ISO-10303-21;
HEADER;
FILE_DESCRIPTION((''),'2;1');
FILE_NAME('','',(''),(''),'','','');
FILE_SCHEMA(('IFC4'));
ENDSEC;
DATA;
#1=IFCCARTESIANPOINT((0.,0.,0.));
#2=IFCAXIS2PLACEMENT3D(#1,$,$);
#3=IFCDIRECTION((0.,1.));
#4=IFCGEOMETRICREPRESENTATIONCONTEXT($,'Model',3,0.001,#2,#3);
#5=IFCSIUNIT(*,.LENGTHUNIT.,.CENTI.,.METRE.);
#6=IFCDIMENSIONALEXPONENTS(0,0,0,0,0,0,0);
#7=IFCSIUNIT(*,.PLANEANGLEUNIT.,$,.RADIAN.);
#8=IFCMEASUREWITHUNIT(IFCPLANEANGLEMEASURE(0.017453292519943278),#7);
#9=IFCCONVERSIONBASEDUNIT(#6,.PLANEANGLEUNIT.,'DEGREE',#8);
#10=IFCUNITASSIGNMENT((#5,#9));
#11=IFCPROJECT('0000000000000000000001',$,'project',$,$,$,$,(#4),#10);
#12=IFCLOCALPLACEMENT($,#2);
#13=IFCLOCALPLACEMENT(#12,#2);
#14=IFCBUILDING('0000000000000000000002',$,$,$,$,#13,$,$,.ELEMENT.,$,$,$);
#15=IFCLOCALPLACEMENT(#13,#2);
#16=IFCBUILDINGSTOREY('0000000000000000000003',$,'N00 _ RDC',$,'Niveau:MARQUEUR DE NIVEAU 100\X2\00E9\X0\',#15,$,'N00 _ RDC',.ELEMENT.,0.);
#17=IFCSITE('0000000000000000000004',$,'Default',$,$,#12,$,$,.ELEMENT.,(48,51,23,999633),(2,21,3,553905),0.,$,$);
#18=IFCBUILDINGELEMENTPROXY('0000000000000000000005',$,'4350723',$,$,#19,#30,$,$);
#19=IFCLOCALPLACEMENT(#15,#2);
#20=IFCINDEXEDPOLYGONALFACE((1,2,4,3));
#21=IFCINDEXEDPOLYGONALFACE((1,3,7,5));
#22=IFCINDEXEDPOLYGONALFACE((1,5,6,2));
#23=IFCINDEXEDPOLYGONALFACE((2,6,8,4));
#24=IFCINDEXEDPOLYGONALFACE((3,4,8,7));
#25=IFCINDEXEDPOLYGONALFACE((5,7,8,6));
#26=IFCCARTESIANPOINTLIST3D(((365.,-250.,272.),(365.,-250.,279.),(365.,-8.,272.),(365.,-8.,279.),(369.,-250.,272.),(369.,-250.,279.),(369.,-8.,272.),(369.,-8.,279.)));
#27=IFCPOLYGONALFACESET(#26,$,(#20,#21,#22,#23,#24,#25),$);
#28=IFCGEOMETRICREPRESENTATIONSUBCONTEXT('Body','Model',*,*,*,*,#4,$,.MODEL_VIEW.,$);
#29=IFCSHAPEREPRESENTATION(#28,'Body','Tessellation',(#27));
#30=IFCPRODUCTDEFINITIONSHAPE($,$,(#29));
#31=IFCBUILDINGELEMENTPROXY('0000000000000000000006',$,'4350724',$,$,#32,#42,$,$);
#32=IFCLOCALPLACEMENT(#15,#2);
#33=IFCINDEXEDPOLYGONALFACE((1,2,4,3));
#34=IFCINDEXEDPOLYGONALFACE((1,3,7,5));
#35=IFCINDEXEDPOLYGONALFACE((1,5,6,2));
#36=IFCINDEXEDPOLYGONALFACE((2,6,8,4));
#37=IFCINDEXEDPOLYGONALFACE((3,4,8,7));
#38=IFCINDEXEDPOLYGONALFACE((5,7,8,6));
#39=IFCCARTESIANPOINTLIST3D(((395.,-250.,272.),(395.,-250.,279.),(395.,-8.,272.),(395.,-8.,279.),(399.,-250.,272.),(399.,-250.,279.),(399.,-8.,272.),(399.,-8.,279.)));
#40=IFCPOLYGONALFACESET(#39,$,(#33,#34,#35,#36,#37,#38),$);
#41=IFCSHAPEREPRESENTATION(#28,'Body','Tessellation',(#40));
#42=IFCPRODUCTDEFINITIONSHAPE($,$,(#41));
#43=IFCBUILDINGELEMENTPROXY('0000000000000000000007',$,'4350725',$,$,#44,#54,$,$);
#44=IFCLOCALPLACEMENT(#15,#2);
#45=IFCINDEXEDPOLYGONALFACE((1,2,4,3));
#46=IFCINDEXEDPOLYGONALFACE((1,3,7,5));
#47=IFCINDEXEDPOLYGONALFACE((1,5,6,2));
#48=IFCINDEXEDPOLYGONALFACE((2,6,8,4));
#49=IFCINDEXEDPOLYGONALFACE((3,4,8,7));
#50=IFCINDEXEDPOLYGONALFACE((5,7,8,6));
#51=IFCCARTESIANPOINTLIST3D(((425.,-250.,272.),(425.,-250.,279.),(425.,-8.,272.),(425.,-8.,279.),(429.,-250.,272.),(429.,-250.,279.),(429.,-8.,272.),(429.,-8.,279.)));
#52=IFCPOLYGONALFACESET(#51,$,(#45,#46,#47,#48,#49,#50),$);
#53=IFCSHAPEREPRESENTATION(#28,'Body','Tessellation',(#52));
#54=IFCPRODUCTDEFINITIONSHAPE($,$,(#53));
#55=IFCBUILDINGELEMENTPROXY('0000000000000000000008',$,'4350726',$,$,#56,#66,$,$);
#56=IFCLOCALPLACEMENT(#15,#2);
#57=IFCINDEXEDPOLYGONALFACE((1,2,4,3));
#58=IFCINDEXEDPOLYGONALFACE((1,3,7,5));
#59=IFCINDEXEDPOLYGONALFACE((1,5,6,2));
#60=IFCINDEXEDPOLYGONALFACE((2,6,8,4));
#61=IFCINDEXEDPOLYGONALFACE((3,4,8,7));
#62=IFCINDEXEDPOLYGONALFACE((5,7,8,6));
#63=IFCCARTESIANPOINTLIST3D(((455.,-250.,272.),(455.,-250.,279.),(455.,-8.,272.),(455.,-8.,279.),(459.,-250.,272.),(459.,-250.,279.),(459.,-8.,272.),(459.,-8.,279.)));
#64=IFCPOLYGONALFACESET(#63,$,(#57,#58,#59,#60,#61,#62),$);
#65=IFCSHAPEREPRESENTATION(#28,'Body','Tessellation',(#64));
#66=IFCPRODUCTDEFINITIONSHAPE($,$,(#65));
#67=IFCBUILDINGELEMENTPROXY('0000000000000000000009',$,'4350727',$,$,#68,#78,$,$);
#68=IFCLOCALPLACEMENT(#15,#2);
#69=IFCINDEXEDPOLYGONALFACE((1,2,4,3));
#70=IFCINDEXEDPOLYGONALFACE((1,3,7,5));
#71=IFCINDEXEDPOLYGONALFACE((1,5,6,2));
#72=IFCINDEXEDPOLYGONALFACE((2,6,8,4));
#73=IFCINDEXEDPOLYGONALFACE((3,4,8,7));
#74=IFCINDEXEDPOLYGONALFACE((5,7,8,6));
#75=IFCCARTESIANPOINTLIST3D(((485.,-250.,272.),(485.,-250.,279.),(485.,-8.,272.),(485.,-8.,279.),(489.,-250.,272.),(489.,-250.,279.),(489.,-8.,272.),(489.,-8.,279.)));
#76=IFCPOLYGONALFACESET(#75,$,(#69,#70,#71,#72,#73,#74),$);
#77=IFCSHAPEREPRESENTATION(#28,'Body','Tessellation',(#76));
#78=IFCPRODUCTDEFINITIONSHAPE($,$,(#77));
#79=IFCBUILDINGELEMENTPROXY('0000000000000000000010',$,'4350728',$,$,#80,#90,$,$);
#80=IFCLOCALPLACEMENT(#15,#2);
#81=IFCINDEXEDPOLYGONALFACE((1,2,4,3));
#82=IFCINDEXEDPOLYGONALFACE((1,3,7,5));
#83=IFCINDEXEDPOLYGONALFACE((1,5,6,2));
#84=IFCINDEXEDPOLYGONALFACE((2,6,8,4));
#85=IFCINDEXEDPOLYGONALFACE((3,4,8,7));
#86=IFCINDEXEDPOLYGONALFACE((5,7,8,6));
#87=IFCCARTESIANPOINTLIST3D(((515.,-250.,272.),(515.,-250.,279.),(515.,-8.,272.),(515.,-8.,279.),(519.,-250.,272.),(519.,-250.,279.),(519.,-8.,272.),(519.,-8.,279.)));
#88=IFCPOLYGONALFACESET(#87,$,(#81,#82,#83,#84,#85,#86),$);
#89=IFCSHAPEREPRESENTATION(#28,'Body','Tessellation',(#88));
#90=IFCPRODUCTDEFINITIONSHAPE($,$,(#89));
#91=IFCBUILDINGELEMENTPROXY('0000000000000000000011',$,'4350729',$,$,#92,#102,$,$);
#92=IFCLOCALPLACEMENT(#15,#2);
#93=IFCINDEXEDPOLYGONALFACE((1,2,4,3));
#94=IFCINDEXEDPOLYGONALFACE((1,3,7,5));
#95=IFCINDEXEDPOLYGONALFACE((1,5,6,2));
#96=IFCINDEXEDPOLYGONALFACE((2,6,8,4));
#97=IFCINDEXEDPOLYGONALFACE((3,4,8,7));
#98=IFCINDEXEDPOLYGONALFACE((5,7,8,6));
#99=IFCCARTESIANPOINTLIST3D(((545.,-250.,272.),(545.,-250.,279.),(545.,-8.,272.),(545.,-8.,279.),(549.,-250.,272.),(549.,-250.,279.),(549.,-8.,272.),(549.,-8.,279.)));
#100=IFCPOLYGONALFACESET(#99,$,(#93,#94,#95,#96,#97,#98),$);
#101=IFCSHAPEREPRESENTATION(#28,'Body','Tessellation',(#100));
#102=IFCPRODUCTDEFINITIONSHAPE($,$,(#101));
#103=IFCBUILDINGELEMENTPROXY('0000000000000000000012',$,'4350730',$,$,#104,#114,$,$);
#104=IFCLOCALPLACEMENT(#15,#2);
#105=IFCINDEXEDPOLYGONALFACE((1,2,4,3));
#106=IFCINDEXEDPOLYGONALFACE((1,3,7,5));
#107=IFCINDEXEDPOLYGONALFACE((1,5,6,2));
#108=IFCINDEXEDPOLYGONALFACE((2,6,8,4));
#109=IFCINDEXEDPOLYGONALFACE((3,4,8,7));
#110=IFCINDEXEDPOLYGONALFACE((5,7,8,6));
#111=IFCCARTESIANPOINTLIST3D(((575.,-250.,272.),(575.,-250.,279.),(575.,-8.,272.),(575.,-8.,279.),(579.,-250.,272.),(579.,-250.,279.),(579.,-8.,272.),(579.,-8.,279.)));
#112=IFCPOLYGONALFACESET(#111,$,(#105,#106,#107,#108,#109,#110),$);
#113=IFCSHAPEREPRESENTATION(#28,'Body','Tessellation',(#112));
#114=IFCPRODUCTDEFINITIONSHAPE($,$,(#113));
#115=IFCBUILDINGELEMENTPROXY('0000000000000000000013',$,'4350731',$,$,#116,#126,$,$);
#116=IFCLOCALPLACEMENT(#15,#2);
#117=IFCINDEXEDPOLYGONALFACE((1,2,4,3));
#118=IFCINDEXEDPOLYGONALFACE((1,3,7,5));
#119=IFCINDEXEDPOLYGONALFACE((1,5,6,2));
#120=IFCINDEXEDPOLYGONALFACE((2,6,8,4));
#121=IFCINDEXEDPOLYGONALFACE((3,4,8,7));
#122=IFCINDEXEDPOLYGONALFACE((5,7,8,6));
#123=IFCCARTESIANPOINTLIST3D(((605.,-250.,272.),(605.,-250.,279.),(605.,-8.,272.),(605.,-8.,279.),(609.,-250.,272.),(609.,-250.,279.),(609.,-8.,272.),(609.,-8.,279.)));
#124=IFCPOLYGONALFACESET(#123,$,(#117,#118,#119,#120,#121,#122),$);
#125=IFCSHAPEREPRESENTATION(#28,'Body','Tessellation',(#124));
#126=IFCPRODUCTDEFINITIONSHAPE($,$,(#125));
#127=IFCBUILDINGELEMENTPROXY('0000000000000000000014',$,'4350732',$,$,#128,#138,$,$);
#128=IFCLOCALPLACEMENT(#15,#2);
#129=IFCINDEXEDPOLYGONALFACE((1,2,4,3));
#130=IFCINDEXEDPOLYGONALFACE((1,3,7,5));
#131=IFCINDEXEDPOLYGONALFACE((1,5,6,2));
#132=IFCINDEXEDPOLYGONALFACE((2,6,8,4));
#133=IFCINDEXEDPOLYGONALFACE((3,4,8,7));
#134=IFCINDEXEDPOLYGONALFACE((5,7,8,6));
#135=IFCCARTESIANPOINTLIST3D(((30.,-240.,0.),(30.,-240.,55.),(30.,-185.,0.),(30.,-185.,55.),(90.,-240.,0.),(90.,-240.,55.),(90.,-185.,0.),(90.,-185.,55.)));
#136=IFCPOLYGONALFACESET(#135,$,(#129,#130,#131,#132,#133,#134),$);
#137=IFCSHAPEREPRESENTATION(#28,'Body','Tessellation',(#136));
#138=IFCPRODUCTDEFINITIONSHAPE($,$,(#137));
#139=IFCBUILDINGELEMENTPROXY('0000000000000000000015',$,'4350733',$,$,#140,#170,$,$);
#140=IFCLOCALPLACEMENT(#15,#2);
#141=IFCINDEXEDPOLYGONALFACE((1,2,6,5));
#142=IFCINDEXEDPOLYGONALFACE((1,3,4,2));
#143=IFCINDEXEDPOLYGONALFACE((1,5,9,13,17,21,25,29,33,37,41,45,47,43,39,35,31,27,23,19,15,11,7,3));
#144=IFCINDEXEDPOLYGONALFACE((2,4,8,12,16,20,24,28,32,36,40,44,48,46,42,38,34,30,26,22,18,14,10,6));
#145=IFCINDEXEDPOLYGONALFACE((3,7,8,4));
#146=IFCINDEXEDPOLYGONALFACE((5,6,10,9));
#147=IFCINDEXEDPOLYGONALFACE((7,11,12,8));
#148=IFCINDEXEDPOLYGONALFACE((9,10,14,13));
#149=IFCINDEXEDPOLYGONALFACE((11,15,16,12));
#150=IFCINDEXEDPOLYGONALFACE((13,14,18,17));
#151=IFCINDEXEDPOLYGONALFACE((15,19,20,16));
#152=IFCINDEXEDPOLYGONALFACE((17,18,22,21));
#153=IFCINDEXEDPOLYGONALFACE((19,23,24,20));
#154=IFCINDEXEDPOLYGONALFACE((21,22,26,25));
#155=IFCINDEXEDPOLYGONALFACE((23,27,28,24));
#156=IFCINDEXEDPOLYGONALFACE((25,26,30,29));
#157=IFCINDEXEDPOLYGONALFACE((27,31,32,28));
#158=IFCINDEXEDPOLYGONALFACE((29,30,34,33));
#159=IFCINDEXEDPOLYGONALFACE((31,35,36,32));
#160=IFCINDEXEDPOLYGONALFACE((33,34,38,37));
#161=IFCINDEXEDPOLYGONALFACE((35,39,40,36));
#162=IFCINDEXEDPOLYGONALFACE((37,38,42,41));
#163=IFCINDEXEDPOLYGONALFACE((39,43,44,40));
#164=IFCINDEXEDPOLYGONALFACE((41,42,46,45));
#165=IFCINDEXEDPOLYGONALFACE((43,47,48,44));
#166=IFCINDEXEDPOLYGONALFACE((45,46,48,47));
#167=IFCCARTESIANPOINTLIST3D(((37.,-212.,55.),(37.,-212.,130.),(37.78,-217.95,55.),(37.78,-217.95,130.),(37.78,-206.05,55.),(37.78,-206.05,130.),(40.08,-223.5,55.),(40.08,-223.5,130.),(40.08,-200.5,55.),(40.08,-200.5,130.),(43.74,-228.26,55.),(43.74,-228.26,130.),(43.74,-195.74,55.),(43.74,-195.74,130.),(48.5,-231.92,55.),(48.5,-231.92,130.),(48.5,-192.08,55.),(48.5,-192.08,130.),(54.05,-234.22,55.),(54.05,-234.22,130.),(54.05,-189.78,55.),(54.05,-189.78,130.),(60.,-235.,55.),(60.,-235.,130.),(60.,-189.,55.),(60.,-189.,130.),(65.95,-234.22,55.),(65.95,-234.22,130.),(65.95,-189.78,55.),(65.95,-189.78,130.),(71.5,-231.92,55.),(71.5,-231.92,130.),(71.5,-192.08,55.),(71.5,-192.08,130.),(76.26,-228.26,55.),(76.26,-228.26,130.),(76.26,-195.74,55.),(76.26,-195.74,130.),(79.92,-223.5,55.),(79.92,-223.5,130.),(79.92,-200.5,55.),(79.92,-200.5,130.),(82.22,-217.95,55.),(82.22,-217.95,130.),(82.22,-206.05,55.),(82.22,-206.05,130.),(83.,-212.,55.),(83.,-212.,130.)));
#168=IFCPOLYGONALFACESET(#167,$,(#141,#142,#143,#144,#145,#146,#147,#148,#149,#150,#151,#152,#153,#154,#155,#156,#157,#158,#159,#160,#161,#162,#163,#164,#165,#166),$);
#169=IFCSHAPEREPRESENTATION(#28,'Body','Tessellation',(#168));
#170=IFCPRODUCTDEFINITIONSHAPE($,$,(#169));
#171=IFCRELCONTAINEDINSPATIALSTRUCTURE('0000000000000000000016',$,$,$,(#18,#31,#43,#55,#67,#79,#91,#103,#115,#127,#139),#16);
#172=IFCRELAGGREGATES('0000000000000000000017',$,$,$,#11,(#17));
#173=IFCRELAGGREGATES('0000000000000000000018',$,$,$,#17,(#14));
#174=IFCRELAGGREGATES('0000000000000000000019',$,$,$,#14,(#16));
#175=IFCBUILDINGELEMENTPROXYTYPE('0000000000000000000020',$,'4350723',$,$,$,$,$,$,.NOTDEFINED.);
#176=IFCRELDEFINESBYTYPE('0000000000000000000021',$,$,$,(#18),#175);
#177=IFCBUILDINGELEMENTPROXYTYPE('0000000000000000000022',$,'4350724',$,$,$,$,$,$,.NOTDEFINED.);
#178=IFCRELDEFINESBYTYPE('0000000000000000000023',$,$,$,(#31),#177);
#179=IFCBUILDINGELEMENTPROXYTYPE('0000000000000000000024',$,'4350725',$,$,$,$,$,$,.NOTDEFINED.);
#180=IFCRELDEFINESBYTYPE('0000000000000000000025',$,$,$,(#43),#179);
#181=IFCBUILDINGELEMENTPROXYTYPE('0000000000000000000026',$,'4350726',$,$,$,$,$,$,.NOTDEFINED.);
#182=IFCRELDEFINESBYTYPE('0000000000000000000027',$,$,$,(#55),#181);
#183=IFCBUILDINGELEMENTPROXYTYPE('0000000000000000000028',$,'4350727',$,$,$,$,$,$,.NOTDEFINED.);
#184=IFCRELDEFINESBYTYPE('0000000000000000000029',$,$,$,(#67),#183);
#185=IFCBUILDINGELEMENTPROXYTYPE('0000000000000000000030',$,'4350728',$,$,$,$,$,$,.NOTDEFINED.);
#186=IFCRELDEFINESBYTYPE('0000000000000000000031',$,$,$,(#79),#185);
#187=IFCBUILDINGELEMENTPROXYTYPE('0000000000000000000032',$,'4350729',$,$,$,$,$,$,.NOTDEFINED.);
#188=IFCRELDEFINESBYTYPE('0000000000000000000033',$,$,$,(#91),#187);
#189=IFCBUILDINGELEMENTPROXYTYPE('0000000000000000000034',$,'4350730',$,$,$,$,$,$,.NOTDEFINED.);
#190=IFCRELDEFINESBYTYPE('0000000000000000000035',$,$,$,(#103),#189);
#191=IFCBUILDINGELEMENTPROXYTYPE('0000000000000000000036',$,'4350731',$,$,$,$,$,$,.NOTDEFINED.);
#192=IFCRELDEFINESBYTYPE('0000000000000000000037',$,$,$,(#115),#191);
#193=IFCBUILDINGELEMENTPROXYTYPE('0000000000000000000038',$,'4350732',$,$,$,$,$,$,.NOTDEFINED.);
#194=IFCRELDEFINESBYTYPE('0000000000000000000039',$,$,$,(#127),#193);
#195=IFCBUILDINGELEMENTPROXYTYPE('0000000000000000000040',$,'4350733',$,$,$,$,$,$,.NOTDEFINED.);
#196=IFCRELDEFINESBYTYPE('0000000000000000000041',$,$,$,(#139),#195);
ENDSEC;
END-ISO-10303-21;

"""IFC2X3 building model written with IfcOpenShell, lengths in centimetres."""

from ifc_helpers import new_model, entity, si_unit, converted_unit, direction, frame, frame_2d, origin, origin_2d_with_axis, place, context, subcontext, project, spatial, rectangle, circle, extrude, type_object, element, save


model = new_model("IFC2X3")

# Units and contexts
model_context = context("Model", 3, precision=0.001, world=origin(), true_north=direction((0.0, 1.0)))
body_context = subcontext(model_context, "Body", "Model", "MODEL_VIEW")
ifc_project = project(units=[si_unit("LENGTHUNIT", "METRE", prefix="CENTI"), converted_unit("PLANEANGLEUNIT", "DEGREE", entity("IfcPlaneAngleMeasure", 0.017453292519943278), si_unit("PLANEANGLEUNIT", "RADIAN"), dimensions=[0, 0, 0, 0, 0, 0, 0])], contexts=[model_context])

# Site, building, storey
site_placement = place(None, origin())
site = spatial("IfcSite", under=ifc_project, at=site_placement, Name="Default", CompositionType="ELEMENT", RefLatitude=(48, 51, 23, 999633), RefLongitude=(2, 21, 3, 553905), RefElevation=0.0)
building_placement = place(site_placement, origin())
building = spatial("IfcBuilding", under=site, at=building_placement, CompositionType="ELEMENT")
storey_placement = place(building_placement, origin())
storey = spatial("IfcBuildingStorey", under=building, at=storey_placement, Name="N00 _ RDC", ObjectType="Niveau:MARQUEUR DE NIVEAU 100é", LongName="N00 _ RDC", CompositionType="ELEMENT", Elevation=0.0)

# Building element proxies
building_element_proxy_type_1 = type_object("IfcBuildingElementProxyType", Name="4350723", PredefinedType="NOTDEFINED")
proxy_1_placement = place(storey_placement, origin())
element("IfcBuildingElementProxy", 1, at=proxy_1_placement, inside=storey, type_object=building_element_proxy_type_1, Name="4350723", context=body_context, shape_type="SweptSolid", body=[
    extrude(rectangle(XDim=4.0, YDim=242.0, at=frame_2d((0.0, 0.0), x_axis=(1.0, 0.0))), frame((367.0, -129.0, 272.0)), (0.0, 0.0, 1.0), 7.0),
])
building_element_proxy_type_2 = type_object("IfcBuildingElementProxyType", Name="4350724", PredefinedType="NOTDEFINED")
proxy_2_placement = place(storey_placement, origin())
element("IfcBuildingElementProxy", 2, at=proxy_2_placement, inside=storey, type_object=building_element_proxy_type_2, Name="4350724", context=body_context, shape_type="SweptSolid", body=[
    extrude(rectangle(XDim=4.0, YDim=242.0, at=frame_2d((0.0, 0.0), x_axis=(1.0, 0.0))), frame((397.0, -129.0, 272.0)), (0.0, 0.0, 1.0), 7.0),
])
building_element_proxy_type_3 = type_object("IfcBuildingElementProxyType", Name="4350725", PredefinedType="NOTDEFINED")
proxy_3_placement = place(storey_placement, origin())
element("IfcBuildingElementProxy", 3, at=proxy_3_placement, inside=storey, type_object=building_element_proxy_type_3, Name="4350725", context=body_context, shape_type="SweptSolid", body=[
    extrude(rectangle(XDim=4.0, YDim=242.0, at=frame_2d((0.0, 0.0), x_axis=(1.0, 0.0))), frame((427.0, -129.0, 272.0)), (0.0, 0.0, 1.0), 7.0),
])
building_element_proxy_type_4 = type_object("IfcBuildingElementProxyType", Name="4350726", PredefinedType="NOTDEFINED")
proxy_4_placement = place(storey_placement, origin())
element("IfcBuildingElementProxy", 4, at=proxy_4_placement, inside=storey, type_object=building_element_proxy_type_4, Name="4350726", context=body_context, shape_type="SweptSolid", body=[
    extrude(rectangle(XDim=4.0, YDim=242.0, at=frame_2d((0.0, 0.0), x_axis=(1.0, 0.0))), frame((457.0, -129.0, 272.0)), (0.0, 0.0, 1.0), 7.0),
])
building_element_proxy_type_5 = type_object("IfcBuildingElementProxyType", Name="4350727", PredefinedType="NOTDEFINED")
proxy_5_placement = place(storey_placement, origin())
element("IfcBuildingElementProxy", 5, at=proxy_5_placement, inside=storey, type_object=building_element_proxy_type_5, Name="4350727", context=body_context, shape_type="SweptSolid", body=[
    extrude(rectangle(XDim=4.0, YDim=242.0, at=frame_2d((0.0, 0.0), x_axis=(1.0, 0.0))), frame((487.0, -129.0, 272.0)), (0.0, 0.0, 1.0), 7.0),
])
building_element_proxy_type_6 = type_object("IfcBuildingElementProxyType", Name="4350728", PredefinedType="NOTDEFINED")
proxy_6_placement = place(storey_placement, origin())
element("IfcBuildingElementProxy", 6, at=proxy_6_placement, inside=storey, type_object=building_element_proxy_type_6, Name="4350728", context=body_context, shape_type="SweptSolid", body=[
    extrude(rectangle(XDim=4.0, YDim=242.0, at=frame_2d((0.0, 0.0), x_axis=(1.0, 0.0))), frame((517.0, -129.0, 272.0)), (0.0, 0.0, 1.0), 7.0),
])
building_element_proxy_type_7 = type_object("IfcBuildingElementProxyType", Name="4350729", PredefinedType="NOTDEFINED")
proxy_7_placement = place(storey_placement, origin())
element("IfcBuildingElementProxy", 7, at=proxy_7_placement, inside=storey, type_object=building_element_proxy_type_7, Name="4350729", context=body_context, shape_type="SweptSolid", body=[
    extrude(rectangle(XDim=4.0, YDim=242.0, at=frame_2d((0.0, 0.0), x_axis=(1.0, 0.0))), frame((547.0, -129.0, 272.0)), (0.0, 0.0, 1.0), 7.0),
])
building_element_proxy_type_8 = type_object("IfcBuildingElementProxyType", Name="4350730", PredefinedType="NOTDEFINED")
proxy_8_placement = place(storey_placement, origin())
element("IfcBuildingElementProxy", 8, at=proxy_8_placement, inside=storey, type_object=building_element_proxy_type_8, Name="4350730", context=body_context, shape_type="SweptSolid", body=[
    extrude(rectangle(XDim=4.0, YDim=242.0, at=frame_2d((0.0, 0.0), x_axis=(1.0, 0.0))), frame((577.0, -129.0, 272.0)), (0.0, 0.0, 1.0), 7.0),
])
building_element_proxy_type_9 = type_object("IfcBuildingElementProxyType", Name="4350731", PredefinedType="NOTDEFINED")
proxy_9_placement = place(storey_placement, origin())
element("IfcBuildingElementProxy", 9, at=proxy_9_placement, inside=storey, type_object=building_element_proxy_type_9, Name="4350731", context=body_context, shape_type="SweptSolid", body=[
    extrude(rectangle(XDim=4.0, YDim=242.0, at=frame_2d((0.0, 0.0), x_axis=(1.0, 0.0))), frame((607.0, -129.0, 272.0)), (0.0, 0.0, 1.0), 7.0),
])
building_element_proxy_type_10 = type_object("IfcBuildingElementProxyType", Name="4350732", PredefinedType="NOTDEFINED")
proxy_10_placement = place(storey_placement, origin())
element("IfcBuildingElementProxy", 10, at=proxy_10_placement, inside=storey, type_object=building_element_proxy_type_10, Name="4350732", context=body_context, shape_type="SweptSolid", body=[
    extrude(rectangle(XDim=60.0, YDim=55.0, at=frame_2d((0.0, 0.0), x_axis=(1.0, 0.0))), frame((60.0, -212.5, 0.0)), (0.0, 0.0, 1.0), 55.0),
])
building_element_proxy_type_11 = type_object("IfcBuildingElementProxyType", Name="4350733", PredefinedType="NOTDEFINED")
proxy_11_placement = place(storey_placement, origin())
element("IfcBuildingElementProxy", 11, at=proxy_11_placement, inside=storey, type_object=building_element_proxy_type_11, Name="4350733", context=body_context, shape_type="SweptSolid", body=[
    extrude(circle(Radius=23.0, at=origin_2d_with_axis()), frame((60.0, -212.0, 55.0)), (0.0, 0.0, 1.0), 75.0),
])

save(model, "model.ifc")
